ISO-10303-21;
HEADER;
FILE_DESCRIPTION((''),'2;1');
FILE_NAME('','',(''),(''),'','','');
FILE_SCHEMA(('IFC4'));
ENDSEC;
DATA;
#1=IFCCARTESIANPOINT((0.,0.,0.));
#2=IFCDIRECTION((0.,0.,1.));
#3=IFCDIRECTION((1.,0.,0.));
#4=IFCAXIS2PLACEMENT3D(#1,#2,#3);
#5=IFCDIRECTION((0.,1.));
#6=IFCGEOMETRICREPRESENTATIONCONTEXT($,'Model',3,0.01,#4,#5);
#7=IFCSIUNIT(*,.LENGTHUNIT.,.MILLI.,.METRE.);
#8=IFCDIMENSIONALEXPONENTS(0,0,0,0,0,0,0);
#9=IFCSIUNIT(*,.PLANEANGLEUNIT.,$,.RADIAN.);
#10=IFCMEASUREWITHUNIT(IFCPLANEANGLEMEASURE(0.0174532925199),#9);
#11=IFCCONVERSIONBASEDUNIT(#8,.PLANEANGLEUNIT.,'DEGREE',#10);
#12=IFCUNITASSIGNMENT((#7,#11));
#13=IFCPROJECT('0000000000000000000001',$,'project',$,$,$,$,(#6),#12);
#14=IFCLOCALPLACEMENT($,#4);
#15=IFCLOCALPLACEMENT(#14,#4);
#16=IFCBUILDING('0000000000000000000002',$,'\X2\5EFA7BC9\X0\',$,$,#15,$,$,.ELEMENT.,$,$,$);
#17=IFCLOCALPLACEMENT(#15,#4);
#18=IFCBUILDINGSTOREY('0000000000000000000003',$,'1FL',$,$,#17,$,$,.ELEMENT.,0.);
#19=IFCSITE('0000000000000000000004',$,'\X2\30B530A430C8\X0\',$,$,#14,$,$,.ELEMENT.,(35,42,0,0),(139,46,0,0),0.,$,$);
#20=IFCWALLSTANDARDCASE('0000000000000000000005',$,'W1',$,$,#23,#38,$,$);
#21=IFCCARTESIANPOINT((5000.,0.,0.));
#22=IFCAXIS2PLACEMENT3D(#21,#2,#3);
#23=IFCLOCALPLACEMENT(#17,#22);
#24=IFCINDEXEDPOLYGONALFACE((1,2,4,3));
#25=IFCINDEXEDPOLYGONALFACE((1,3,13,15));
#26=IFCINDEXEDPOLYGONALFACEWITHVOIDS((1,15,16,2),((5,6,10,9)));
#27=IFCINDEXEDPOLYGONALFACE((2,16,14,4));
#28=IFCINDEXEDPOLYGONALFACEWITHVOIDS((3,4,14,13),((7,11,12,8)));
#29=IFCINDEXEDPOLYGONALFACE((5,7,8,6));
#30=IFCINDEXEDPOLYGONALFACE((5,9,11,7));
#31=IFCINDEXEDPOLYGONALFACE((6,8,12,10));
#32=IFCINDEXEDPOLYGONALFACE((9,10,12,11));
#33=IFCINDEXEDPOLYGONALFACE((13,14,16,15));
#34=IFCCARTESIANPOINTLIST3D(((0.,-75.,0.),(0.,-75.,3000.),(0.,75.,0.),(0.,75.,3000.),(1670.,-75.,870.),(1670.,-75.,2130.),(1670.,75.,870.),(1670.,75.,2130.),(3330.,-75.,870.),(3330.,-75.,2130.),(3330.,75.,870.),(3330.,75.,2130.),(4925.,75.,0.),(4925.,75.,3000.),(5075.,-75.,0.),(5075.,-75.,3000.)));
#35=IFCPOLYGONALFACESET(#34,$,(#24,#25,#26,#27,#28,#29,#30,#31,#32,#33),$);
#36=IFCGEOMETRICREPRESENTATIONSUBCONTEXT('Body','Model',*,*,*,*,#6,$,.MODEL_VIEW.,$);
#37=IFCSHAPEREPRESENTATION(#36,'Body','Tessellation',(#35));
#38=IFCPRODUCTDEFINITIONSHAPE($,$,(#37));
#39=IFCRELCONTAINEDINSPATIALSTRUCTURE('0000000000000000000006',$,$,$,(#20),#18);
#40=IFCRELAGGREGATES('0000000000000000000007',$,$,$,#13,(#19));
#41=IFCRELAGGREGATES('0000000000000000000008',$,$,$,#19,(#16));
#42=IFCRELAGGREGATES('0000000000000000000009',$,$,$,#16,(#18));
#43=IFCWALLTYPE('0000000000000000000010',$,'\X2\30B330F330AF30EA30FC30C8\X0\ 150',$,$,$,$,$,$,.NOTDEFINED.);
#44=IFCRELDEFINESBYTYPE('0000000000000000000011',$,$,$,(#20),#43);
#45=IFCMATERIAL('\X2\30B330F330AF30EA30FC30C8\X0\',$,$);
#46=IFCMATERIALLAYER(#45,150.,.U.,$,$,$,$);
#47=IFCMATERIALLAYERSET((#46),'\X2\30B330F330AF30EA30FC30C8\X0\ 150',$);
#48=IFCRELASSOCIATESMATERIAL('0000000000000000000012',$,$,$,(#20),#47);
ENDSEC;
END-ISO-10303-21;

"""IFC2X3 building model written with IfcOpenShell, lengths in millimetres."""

from ifc_helpers import new_model, entity, si_unit, converted_unit, direction, frame, origin_with_axes, origin_2d_with_axis, place, context, subcontext, project, spatial, polyline, rectangle, outline, extrude, material, layer, layer_set, layer_usage, type_object, element, save


model = new_model("IFC2X3")

# Units and contexts
model_context = context("Model", 3, precision=0.01, world=origin_with_axes(), true_north=direction((0.0, 1.0)))
body_context = subcontext(model_context, "Body", "Model", "MODEL_VIEW")
ifc_project = project(units=[si_unit("LENGTHUNIT", "METRE", prefix="MILLI"), converted_unit("PLANEANGLEUNIT", "DEGREE", entity("IfcPlaneAngleMeasure", 0.0174532925199), si_unit("PLANEANGLEUNIT", "RADIAN"), dimensions=[0, 0, 0, 0, 0, 0, 0])], contexts=[model_context])

# Site, building, storey
site_placement = place(None, origin_with_axes())
site = spatial("IfcSite", under=ifc_project, at=site_placement, Name="サイト", CompositionType="ELEMENT", RefLatitude=(35, 42, 0, 0), RefLongitude=(139, 46, 0, 0), RefElevation=0.0)
building_placement = place(site_placement, origin_with_axes())
building = spatial("IfcBuilding", under=site, at=building_placement, Name="建築", CompositionType="ELEMENT")
storey_placement = place(building_placement, origin_with_axes())
storey = spatial("IfcBuildingStorey", under=building, at=storey_placement, Name="1FL", CompositionType="ELEMENT", Elevation=0.0)

# Shared definitions
ifc_material_1 = material(Name="コンクリート")

# Wall, opening
ifc_layer_1 = layer(ifc_material_1, 150.0, ventilated="UNKNOWN")
ifc_layer_set_1 = layer_set([ifc_layer_1], Name="コンクリート 150")
wall_type_1 = type_object("IfcWallType", Name="コンクリート 150", PredefinedType="NOTDEFINED")
ifc_layer_usage_1 = layer_usage(ifc_layer_set_1, "AXIS2", "POSITIVE", -75.0)
wall_1_placement = place(storey_placement, frame((5000.0, 0.0, 0.0), z_axis=(0.0, 0.0, 1.0), x_axis=(1.0, 0.0, 0.0)))
wall_1 = element("IfcWallStandardCase", 1, at=wall_1_placement, inside=storey, type_object=wall_type_1, material=ifc_layer_usage_1, Name="W1", context=body_context, shape_type="SweptSolid", body=[
    extrude(outline(polyline([(0.0, -75.0), (5075.0, -75.0), (4925.0, 75.0), (0.0, 75.0), (0.0, -75.0)])), origin_with_axes(), (0.0, 0.0, 1.0), 3000.0),
])
opening_1_placement = place(wall_1_placement, frame((2500.0, 0.0, 900.0), z_axis=(0.0, 0.0, 1.0), x_axis=(1.0, 0.0, 0.0)))
element("IfcOpeningElement", 2, at=opening_1_placement, cuts=wall_1, context=body_context, shape_type="SweptSolid", body=[
    extrude(rectangle(XDim=1660.0, YDim=1260.0, at=origin_2d_with_axis()), frame((0.0, -195.0, 600.0), z_axis=(0.0, -1.0, 0.0), x_axis=(1.0, 0.0, 0.0)), (0.0, 0.0, -1.0), 390.0),
])

save(model, "model.ifc")
